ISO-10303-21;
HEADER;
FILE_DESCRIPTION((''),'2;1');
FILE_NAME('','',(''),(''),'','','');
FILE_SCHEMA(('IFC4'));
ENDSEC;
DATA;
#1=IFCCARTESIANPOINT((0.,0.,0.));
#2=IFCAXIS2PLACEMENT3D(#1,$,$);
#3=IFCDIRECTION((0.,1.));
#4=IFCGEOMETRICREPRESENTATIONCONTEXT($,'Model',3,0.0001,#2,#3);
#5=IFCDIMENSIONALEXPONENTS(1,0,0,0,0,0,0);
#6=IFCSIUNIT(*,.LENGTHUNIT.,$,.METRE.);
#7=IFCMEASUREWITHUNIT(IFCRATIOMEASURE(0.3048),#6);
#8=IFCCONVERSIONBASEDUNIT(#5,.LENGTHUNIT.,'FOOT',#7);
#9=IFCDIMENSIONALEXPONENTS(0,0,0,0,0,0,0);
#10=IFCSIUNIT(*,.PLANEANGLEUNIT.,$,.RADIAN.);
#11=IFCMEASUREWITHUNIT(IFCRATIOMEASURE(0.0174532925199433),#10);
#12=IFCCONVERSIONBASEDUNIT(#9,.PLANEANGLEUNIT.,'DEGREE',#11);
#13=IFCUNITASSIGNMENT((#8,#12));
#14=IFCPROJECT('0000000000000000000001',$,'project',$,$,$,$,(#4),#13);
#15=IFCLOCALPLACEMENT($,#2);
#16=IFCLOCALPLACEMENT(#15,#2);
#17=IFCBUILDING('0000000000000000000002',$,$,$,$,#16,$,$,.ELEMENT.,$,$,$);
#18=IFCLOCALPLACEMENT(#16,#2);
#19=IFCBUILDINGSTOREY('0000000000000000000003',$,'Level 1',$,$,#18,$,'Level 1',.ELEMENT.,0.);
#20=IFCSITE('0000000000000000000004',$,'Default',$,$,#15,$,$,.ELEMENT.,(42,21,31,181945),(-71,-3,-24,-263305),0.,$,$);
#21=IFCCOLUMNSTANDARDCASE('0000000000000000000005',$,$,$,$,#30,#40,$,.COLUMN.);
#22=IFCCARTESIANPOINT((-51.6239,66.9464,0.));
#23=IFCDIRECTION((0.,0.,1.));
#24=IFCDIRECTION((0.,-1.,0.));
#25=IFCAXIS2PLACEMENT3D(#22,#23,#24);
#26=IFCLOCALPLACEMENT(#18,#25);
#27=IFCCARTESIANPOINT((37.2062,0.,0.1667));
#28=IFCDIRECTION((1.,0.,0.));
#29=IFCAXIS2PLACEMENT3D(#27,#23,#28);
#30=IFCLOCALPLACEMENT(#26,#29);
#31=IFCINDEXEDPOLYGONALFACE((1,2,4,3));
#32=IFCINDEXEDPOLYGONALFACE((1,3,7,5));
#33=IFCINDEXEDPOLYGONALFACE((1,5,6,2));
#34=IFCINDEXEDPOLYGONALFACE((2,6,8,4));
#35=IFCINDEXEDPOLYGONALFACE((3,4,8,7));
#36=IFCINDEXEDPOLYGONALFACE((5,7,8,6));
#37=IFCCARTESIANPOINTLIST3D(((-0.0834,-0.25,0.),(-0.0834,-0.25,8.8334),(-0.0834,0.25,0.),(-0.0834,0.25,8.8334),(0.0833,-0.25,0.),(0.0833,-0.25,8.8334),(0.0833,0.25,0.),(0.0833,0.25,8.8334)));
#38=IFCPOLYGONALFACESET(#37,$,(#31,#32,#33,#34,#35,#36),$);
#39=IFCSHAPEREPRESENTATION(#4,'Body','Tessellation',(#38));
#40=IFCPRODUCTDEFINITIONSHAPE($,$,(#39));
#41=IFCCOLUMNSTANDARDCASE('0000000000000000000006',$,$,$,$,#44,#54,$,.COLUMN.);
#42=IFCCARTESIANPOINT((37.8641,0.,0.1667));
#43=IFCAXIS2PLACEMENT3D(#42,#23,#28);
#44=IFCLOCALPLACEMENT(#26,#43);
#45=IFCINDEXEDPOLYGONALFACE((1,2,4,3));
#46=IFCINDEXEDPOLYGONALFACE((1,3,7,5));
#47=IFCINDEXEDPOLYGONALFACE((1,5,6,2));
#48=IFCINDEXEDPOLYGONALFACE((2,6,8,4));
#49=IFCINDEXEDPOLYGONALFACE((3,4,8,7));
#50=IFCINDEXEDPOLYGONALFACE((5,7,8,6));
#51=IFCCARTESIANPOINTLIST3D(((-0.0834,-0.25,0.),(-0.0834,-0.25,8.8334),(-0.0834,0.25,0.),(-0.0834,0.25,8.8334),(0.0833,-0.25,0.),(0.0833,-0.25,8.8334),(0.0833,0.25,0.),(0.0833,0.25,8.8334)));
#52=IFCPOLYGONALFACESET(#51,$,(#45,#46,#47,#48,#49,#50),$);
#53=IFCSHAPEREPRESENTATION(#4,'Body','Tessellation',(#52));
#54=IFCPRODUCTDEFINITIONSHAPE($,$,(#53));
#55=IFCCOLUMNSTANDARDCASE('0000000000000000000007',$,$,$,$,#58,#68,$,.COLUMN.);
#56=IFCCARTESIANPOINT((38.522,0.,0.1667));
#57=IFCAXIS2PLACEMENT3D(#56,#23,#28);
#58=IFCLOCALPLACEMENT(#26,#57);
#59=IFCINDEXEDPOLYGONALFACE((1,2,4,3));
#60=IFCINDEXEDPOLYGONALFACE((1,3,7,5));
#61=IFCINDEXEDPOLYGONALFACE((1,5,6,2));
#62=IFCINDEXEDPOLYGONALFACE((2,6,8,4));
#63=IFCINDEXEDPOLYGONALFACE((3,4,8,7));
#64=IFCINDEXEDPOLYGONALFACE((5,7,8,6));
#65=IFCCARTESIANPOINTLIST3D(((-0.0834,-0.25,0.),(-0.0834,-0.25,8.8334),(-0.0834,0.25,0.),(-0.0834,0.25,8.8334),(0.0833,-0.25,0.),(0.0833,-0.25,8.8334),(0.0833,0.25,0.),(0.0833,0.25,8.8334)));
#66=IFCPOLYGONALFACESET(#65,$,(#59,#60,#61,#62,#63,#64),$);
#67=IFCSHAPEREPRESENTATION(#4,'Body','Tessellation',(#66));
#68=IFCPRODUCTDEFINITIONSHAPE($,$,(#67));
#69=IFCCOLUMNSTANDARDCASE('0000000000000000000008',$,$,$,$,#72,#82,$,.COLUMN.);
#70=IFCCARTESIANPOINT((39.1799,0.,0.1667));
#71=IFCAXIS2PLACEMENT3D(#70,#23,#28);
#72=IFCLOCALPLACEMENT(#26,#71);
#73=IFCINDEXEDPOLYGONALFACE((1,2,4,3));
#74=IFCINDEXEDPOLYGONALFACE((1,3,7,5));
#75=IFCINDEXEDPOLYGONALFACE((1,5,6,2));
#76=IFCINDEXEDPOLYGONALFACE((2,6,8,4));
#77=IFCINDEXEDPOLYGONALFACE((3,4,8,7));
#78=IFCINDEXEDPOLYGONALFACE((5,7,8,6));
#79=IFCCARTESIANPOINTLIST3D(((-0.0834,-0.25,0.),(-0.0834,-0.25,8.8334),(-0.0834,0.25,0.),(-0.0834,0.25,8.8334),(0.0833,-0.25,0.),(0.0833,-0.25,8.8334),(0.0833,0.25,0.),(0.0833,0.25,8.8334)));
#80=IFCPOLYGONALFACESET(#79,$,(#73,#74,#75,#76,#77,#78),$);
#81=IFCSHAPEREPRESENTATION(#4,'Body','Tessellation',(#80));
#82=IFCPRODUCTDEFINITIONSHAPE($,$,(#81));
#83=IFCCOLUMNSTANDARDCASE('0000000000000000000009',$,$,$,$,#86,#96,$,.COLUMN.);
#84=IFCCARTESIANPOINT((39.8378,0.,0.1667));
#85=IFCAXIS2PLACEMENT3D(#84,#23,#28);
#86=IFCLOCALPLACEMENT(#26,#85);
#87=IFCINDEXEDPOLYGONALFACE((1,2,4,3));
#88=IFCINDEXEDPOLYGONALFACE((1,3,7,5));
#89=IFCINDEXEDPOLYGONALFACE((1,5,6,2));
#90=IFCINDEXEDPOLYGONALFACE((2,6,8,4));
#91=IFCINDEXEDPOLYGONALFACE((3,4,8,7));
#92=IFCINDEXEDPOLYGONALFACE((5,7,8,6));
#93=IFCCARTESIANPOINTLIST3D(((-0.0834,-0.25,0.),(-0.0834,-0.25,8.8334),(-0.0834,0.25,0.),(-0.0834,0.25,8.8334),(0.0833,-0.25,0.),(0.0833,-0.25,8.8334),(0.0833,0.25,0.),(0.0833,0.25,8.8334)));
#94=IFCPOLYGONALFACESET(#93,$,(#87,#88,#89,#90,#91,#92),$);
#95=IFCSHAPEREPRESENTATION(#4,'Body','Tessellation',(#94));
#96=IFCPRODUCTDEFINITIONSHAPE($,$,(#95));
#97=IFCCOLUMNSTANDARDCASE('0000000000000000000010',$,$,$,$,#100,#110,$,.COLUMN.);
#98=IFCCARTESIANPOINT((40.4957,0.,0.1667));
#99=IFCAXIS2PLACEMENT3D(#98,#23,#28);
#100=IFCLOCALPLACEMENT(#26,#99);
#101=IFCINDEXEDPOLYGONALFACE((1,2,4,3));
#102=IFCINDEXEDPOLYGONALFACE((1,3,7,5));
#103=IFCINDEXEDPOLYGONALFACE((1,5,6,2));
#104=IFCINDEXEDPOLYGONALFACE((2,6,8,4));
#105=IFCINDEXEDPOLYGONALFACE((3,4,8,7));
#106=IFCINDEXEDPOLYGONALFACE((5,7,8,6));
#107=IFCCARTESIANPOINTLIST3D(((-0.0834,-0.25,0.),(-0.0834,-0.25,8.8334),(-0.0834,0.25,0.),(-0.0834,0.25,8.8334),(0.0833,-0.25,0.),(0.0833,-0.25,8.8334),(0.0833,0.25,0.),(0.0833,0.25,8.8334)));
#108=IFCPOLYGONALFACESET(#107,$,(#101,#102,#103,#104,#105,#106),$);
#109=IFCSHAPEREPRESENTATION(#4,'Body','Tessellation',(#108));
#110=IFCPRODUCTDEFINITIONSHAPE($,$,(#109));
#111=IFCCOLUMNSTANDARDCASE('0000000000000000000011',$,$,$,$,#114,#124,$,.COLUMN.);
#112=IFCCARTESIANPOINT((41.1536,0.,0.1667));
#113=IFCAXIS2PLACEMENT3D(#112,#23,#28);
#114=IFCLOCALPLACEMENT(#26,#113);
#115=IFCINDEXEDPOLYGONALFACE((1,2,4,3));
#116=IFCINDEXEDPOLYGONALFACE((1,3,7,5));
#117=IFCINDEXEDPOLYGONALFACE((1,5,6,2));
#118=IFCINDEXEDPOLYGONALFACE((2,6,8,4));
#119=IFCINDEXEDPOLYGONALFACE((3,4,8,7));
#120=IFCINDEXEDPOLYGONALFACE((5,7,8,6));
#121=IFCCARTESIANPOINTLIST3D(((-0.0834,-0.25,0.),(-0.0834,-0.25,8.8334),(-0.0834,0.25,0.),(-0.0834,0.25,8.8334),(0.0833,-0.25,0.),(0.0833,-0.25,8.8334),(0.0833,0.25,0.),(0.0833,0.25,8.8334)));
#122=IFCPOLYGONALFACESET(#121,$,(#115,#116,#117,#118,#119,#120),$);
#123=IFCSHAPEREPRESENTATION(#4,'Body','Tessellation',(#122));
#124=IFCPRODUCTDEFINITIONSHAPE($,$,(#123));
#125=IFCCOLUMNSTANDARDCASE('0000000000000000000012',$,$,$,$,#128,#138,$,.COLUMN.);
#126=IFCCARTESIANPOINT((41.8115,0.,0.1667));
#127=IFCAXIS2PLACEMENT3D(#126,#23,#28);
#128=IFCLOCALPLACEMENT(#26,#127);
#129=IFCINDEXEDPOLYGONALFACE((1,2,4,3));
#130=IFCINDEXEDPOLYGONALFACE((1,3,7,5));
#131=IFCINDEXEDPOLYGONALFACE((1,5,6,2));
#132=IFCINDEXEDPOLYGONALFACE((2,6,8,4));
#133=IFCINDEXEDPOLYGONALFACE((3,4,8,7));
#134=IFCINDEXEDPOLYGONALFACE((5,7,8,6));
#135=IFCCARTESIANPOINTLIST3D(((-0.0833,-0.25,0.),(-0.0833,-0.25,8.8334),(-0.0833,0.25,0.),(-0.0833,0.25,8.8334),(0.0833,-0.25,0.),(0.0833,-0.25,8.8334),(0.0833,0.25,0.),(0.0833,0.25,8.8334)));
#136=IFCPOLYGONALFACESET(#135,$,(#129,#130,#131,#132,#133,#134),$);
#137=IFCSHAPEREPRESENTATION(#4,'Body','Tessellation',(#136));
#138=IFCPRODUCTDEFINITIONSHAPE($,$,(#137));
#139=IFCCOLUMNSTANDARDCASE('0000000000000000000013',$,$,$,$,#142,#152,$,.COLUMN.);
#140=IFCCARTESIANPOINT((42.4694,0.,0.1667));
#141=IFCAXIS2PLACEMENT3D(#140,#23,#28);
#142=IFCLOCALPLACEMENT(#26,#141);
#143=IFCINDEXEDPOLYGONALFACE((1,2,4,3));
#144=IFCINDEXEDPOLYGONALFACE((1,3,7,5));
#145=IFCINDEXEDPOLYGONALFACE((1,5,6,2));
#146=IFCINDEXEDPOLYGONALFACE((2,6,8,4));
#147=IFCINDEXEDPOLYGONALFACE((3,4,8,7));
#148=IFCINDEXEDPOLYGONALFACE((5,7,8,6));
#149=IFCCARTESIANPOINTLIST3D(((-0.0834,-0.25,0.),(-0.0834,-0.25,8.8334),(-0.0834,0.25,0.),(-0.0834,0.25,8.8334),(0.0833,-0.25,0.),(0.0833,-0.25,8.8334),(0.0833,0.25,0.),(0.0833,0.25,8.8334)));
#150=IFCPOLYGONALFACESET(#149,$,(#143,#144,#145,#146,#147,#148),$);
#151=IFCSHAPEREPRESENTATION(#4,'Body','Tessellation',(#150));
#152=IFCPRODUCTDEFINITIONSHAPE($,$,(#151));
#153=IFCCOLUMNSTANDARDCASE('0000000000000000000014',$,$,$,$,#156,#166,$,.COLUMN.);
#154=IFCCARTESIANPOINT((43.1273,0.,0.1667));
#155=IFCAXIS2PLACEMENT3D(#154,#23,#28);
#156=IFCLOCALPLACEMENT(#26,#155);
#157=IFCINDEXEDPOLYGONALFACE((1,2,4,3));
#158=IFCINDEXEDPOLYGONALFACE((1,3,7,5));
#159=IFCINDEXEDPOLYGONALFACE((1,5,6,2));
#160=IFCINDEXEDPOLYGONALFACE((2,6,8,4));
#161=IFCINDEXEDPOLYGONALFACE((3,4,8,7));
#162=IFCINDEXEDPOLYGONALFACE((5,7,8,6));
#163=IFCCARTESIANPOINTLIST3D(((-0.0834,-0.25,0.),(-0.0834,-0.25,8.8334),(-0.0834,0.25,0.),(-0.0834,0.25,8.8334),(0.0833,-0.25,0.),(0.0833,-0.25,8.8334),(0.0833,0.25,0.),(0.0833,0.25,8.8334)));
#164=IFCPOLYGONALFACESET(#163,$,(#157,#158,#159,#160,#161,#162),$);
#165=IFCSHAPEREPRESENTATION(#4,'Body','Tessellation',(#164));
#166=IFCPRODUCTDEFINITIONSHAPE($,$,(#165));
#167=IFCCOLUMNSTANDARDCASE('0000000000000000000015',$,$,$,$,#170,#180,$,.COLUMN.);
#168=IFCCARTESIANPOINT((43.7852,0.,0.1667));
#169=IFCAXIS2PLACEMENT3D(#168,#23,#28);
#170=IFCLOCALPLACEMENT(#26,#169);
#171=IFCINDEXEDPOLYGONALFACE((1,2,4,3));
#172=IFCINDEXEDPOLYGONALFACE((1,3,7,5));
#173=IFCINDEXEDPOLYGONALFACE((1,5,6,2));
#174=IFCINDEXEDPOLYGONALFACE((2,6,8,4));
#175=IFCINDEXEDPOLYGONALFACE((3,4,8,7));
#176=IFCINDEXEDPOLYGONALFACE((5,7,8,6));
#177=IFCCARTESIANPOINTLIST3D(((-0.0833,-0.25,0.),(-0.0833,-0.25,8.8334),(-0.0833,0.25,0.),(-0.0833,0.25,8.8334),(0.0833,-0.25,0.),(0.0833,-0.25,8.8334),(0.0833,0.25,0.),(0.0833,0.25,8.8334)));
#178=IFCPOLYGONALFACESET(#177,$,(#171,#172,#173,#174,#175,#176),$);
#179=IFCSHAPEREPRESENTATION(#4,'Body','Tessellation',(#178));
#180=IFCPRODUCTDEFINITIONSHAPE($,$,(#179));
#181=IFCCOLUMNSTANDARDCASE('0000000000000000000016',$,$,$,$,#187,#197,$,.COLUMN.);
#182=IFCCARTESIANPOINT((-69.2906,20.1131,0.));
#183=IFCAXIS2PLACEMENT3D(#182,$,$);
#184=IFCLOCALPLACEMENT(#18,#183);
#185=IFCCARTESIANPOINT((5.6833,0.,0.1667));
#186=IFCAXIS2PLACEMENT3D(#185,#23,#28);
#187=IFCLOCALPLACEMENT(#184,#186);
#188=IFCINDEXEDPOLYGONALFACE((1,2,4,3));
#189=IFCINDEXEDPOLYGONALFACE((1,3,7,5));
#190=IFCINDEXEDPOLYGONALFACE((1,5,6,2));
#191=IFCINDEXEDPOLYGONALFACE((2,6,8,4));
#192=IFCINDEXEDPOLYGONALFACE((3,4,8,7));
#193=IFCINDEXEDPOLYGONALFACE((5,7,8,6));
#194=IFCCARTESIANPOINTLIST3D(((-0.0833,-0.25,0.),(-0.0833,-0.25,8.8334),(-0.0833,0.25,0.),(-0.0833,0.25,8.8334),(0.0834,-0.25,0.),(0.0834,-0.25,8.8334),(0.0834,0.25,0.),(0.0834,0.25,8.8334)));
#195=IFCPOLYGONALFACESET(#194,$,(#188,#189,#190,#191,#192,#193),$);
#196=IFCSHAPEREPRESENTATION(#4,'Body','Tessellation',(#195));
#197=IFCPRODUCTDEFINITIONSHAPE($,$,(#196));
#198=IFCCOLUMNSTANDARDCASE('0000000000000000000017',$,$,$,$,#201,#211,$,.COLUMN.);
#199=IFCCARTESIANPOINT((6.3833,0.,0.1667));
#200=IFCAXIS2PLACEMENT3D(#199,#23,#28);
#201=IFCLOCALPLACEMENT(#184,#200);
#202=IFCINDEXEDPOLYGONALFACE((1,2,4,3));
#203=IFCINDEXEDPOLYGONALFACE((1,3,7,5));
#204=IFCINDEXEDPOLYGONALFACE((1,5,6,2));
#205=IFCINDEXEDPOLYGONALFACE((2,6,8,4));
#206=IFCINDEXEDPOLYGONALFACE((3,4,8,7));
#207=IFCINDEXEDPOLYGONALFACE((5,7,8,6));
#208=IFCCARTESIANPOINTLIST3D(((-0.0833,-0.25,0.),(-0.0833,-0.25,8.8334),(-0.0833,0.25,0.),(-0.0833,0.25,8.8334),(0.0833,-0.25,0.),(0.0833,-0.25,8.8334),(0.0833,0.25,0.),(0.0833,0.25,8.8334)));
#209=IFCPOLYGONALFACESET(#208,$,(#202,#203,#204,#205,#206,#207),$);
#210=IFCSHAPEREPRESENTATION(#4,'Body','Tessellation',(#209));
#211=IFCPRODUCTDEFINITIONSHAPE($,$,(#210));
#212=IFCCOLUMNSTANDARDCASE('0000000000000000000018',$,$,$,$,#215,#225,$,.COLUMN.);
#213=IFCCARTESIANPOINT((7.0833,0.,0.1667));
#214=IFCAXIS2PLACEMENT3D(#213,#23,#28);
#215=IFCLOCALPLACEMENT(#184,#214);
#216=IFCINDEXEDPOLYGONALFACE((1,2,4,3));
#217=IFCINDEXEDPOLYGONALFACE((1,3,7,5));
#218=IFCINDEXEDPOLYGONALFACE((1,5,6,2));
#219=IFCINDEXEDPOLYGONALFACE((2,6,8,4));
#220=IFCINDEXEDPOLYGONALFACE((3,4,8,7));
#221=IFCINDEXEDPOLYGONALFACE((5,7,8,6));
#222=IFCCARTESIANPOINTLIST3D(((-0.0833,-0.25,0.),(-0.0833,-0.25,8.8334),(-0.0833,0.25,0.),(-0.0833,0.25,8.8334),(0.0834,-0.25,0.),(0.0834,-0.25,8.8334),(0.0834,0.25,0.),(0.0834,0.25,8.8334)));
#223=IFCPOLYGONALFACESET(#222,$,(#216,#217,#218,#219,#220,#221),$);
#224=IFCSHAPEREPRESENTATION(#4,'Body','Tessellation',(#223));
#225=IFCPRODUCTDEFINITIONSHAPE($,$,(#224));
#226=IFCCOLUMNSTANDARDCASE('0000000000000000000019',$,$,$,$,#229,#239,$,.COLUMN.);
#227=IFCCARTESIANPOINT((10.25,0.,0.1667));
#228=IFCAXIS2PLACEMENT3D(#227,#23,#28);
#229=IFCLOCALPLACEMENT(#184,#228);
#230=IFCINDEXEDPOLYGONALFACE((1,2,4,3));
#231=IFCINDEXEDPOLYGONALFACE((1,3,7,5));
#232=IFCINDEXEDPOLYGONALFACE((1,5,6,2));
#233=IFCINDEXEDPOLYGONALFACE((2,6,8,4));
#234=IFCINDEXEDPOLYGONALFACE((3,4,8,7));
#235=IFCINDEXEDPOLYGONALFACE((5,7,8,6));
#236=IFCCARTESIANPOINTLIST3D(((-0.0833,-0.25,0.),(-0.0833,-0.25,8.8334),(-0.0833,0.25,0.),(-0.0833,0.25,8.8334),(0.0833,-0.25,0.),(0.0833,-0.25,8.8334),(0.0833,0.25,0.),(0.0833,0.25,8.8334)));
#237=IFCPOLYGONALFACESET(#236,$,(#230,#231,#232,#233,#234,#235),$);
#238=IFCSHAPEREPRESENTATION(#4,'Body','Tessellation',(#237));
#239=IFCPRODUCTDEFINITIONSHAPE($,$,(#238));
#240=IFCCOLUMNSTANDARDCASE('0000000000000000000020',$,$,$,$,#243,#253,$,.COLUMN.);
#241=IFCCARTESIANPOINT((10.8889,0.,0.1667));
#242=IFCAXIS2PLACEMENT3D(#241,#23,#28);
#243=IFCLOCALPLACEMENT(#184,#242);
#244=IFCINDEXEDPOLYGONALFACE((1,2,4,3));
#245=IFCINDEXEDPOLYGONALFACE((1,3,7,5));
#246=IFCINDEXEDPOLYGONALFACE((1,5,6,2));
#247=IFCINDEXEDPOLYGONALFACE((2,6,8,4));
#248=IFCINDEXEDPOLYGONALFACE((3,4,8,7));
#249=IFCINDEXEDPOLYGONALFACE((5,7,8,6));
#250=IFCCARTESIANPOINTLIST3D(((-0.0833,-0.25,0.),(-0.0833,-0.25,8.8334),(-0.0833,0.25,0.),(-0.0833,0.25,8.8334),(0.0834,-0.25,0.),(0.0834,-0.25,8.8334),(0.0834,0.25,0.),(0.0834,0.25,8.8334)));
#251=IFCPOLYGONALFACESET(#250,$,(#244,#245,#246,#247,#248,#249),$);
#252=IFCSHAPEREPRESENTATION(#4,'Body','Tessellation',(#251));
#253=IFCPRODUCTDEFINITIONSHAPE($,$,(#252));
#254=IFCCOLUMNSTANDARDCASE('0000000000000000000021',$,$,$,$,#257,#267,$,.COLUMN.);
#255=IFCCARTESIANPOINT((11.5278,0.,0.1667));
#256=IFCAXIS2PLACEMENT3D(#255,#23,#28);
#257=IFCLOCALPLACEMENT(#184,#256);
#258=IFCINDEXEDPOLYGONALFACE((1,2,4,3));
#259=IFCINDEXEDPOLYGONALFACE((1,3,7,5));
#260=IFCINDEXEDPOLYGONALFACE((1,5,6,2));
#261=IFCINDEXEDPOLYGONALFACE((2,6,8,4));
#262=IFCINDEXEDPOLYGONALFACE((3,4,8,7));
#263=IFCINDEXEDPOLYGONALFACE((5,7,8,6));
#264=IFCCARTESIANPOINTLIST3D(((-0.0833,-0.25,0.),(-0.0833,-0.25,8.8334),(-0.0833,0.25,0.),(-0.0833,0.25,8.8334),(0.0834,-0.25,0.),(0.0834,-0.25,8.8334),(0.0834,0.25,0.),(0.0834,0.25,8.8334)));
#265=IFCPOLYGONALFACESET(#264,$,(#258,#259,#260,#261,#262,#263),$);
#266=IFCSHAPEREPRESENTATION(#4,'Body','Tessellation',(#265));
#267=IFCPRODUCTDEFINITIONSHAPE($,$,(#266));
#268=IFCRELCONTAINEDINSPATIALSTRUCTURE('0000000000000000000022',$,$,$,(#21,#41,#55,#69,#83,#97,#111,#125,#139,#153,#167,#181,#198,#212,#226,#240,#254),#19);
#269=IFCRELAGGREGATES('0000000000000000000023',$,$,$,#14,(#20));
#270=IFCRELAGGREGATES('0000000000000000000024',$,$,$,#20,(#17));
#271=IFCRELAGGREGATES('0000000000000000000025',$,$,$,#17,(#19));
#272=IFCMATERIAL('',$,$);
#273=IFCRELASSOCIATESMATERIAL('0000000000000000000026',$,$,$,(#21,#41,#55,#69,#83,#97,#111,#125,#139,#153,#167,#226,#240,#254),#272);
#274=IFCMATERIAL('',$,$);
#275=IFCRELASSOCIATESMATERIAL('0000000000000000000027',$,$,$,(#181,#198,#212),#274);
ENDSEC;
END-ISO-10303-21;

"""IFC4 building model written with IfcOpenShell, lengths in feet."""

from ifc_helpers import new_model, entity, si_unit, converted_unit, direction, frame, origin, place, context, project, spatial, rectangle, extrude, material, element, save


model = new_model("IFC4")

# Units and contexts
model_context = context("Model", 3, precision=0.0001, world=origin(), true_north=direction((0.0, 1.0)))
ifc_project = project(units=[converted_unit("LENGTHUNIT", "FOOT", entity("IfcRatioMeasure", 0.3048), si_unit("LENGTHUNIT", "METRE"), dimensions=[1, 0, 0, 0, 0, 0, 0]), converted_unit("PLANEANGLEUNIT", "DEGREE", entity("IfcRatioMeasure", 0.0174532925199433), si_unit("PLANEANGLEUNIT", "RADIAN"), dimensions=[0, 0, 0, 0, 0, 0, 0])], contexts=[model_context])

# Site, building, storey
site_placement = place(None, origin())
site = spatial("IfcSite", under=ifc_project, at=site_placement, Name="Default", CompositionType="ELEMENT", RefLatitude=(42, 21, 31, 181945), RefLongitude=(-71, -3, -24, -263305), RefElevation=0.0)
building_placement = place(site_placement, origin())
building = spatial("IfcBuilding", under=site, at=building_placement, CompositionType="ELEMENT")
storey_placement = place(building_placement, origin())
storey = spatial("IfcBuildingStorey", under=building, at=storey_placement, Name="Level 1", LongName="Level 1", CompositionType="ELEMENT", Elevation=0.0)

# Columns
ifc_material_1 = material(Name="")
placement_1 = place(storey_placement, frame((-51.6239, 66.9464, 0.0), z_axis=(0.0, 0.0, 1.0), x_axis=(0.0, -1.0, 0.0)))
for number, where, z_axis, x_axis in (
    (1, (37.2062, 0.0, 0.1667), (0.0, 0.0, 1.0), (1.0, 0.0, 0.0)),
    (2, (37.8641, 0.0, 0.1667), (0.0, 0.0, 1.0), (1.0, 0.0, 0.0)),
    (3, (38.522, 0.0, 0.1667), (0.0, 0.0, 1.0), (1.0, 0.0, 0.0)),
    (4, (39.1799, 0.0, 0.1667), (0.0, 0.0, 1.0), (1.0, 0.0, 0.0)),
    (5, (39.8378, 0.0, 0.1667), (0.0, 0.0, 1.0), (1.0, 0.0, 0.0)),
    (6, (40.4957, 0.0, 0.1667), (0.0, 0.0, 1.0), (1.0, 0.0, 0.0)),
    (7, (41.1536, 0.0, 0.1667), (0.0, 0.0, 1.0), (1.0, 0.0, 0.0)),
    (8, (41.8115, 0.0, 0.1667), (0.0, 0.0, 1.0), (1.0, 0.0, 0.0)),
    (9, (42.4694, 0.0, 0.1667), (0.0, 0.0, 1.0), (1.0, 0.0, 0.0)),
    (10, (43.1273, 0.0, 0.1667), (0.0, 0.0, 1.0), (1.0, 0.0, 0.0)),
    (11, (43.7852, 0.0, 0.1667), (0.0, 0.0, 1.0), (1.0, 0.0, 0.0)),
):
    element("IfcColumnStandardCase", number, at=place(placement_1, frame(where, z_axis=z_axis, x_axis=x_axis)), inside=storey, material=ifc_material_1, PredefinedType="COLUMN", context=model_context, shape_type="SweptSolid", body=[
        extrude(rectangle(XDim=0.1667, YDim=0.5), origin(), (0.0, 0.0, 1.0), 8.8334),
    ])
ifc_material_2 = material(Name="")
placement_2 = place(storey_placement, frame((-69.2906, 20.1131, 0.0)))
for number, where, z_axis, x_axis in (
    (12, (5.6833, 0.0, 0.1667), (0.0, 0.0, 1.0), (1.0, 0.0, 0.0)),
    (13, (6.3833, 0.0, 0.1667), (0.0, 0.0, 1.0), (1.0, 0.0, 0.0)),
    (14, (7.0833, 0.0, 0.1667), (0.0, 0.0, 1.0), (1.0, 0.0, 0.0)),
):
    element("IfcColumnStandardCase", number, at=place(placement_2, frame(where, z_axis=z_axis, x_axis=x_axis)), inside=storey, material=ifc_material_2, PredefinedType="COLUMN", context=model_context, shape_type="SweptSolid", body=[
        extrude(rectangle(XDim=0.1667, YDim=0.5), origin(), (0.0, 0.0, 1.0), 8.8334),
    ])
for number, where, z_axis, x_axis in (
    (15, (10.25, 0.0, 0.1667), (0.0, 0.0, 1.0), (1.0, 0.0, 0.0)),
    (16, (10.8889, 0.0, 0.1667), (0.0, 0.0, 1.0), (1.0, 0.0, 0.0)),
    (17, (11.5278, 0.0, 0.1667), (0.0, 0.0, 1.0), (1.0, 0.0, 0.0)),
):
    element("IfcColumnStandardCase", number, at=place(placement_2, frame(where, z_axis=z_axis, x_axis=x_axis)), inside=storey, material=ifc_material_1, PredefinedType="COLUMN", context=model_context, shape_type="SweptSolid", body=[
        extrude(rectangle(XDim=0.1667, YDim=0.5), origin(), (0.0, 0.0, 1.0), 8.8334),
    ])

save(model, "model.ifc")
